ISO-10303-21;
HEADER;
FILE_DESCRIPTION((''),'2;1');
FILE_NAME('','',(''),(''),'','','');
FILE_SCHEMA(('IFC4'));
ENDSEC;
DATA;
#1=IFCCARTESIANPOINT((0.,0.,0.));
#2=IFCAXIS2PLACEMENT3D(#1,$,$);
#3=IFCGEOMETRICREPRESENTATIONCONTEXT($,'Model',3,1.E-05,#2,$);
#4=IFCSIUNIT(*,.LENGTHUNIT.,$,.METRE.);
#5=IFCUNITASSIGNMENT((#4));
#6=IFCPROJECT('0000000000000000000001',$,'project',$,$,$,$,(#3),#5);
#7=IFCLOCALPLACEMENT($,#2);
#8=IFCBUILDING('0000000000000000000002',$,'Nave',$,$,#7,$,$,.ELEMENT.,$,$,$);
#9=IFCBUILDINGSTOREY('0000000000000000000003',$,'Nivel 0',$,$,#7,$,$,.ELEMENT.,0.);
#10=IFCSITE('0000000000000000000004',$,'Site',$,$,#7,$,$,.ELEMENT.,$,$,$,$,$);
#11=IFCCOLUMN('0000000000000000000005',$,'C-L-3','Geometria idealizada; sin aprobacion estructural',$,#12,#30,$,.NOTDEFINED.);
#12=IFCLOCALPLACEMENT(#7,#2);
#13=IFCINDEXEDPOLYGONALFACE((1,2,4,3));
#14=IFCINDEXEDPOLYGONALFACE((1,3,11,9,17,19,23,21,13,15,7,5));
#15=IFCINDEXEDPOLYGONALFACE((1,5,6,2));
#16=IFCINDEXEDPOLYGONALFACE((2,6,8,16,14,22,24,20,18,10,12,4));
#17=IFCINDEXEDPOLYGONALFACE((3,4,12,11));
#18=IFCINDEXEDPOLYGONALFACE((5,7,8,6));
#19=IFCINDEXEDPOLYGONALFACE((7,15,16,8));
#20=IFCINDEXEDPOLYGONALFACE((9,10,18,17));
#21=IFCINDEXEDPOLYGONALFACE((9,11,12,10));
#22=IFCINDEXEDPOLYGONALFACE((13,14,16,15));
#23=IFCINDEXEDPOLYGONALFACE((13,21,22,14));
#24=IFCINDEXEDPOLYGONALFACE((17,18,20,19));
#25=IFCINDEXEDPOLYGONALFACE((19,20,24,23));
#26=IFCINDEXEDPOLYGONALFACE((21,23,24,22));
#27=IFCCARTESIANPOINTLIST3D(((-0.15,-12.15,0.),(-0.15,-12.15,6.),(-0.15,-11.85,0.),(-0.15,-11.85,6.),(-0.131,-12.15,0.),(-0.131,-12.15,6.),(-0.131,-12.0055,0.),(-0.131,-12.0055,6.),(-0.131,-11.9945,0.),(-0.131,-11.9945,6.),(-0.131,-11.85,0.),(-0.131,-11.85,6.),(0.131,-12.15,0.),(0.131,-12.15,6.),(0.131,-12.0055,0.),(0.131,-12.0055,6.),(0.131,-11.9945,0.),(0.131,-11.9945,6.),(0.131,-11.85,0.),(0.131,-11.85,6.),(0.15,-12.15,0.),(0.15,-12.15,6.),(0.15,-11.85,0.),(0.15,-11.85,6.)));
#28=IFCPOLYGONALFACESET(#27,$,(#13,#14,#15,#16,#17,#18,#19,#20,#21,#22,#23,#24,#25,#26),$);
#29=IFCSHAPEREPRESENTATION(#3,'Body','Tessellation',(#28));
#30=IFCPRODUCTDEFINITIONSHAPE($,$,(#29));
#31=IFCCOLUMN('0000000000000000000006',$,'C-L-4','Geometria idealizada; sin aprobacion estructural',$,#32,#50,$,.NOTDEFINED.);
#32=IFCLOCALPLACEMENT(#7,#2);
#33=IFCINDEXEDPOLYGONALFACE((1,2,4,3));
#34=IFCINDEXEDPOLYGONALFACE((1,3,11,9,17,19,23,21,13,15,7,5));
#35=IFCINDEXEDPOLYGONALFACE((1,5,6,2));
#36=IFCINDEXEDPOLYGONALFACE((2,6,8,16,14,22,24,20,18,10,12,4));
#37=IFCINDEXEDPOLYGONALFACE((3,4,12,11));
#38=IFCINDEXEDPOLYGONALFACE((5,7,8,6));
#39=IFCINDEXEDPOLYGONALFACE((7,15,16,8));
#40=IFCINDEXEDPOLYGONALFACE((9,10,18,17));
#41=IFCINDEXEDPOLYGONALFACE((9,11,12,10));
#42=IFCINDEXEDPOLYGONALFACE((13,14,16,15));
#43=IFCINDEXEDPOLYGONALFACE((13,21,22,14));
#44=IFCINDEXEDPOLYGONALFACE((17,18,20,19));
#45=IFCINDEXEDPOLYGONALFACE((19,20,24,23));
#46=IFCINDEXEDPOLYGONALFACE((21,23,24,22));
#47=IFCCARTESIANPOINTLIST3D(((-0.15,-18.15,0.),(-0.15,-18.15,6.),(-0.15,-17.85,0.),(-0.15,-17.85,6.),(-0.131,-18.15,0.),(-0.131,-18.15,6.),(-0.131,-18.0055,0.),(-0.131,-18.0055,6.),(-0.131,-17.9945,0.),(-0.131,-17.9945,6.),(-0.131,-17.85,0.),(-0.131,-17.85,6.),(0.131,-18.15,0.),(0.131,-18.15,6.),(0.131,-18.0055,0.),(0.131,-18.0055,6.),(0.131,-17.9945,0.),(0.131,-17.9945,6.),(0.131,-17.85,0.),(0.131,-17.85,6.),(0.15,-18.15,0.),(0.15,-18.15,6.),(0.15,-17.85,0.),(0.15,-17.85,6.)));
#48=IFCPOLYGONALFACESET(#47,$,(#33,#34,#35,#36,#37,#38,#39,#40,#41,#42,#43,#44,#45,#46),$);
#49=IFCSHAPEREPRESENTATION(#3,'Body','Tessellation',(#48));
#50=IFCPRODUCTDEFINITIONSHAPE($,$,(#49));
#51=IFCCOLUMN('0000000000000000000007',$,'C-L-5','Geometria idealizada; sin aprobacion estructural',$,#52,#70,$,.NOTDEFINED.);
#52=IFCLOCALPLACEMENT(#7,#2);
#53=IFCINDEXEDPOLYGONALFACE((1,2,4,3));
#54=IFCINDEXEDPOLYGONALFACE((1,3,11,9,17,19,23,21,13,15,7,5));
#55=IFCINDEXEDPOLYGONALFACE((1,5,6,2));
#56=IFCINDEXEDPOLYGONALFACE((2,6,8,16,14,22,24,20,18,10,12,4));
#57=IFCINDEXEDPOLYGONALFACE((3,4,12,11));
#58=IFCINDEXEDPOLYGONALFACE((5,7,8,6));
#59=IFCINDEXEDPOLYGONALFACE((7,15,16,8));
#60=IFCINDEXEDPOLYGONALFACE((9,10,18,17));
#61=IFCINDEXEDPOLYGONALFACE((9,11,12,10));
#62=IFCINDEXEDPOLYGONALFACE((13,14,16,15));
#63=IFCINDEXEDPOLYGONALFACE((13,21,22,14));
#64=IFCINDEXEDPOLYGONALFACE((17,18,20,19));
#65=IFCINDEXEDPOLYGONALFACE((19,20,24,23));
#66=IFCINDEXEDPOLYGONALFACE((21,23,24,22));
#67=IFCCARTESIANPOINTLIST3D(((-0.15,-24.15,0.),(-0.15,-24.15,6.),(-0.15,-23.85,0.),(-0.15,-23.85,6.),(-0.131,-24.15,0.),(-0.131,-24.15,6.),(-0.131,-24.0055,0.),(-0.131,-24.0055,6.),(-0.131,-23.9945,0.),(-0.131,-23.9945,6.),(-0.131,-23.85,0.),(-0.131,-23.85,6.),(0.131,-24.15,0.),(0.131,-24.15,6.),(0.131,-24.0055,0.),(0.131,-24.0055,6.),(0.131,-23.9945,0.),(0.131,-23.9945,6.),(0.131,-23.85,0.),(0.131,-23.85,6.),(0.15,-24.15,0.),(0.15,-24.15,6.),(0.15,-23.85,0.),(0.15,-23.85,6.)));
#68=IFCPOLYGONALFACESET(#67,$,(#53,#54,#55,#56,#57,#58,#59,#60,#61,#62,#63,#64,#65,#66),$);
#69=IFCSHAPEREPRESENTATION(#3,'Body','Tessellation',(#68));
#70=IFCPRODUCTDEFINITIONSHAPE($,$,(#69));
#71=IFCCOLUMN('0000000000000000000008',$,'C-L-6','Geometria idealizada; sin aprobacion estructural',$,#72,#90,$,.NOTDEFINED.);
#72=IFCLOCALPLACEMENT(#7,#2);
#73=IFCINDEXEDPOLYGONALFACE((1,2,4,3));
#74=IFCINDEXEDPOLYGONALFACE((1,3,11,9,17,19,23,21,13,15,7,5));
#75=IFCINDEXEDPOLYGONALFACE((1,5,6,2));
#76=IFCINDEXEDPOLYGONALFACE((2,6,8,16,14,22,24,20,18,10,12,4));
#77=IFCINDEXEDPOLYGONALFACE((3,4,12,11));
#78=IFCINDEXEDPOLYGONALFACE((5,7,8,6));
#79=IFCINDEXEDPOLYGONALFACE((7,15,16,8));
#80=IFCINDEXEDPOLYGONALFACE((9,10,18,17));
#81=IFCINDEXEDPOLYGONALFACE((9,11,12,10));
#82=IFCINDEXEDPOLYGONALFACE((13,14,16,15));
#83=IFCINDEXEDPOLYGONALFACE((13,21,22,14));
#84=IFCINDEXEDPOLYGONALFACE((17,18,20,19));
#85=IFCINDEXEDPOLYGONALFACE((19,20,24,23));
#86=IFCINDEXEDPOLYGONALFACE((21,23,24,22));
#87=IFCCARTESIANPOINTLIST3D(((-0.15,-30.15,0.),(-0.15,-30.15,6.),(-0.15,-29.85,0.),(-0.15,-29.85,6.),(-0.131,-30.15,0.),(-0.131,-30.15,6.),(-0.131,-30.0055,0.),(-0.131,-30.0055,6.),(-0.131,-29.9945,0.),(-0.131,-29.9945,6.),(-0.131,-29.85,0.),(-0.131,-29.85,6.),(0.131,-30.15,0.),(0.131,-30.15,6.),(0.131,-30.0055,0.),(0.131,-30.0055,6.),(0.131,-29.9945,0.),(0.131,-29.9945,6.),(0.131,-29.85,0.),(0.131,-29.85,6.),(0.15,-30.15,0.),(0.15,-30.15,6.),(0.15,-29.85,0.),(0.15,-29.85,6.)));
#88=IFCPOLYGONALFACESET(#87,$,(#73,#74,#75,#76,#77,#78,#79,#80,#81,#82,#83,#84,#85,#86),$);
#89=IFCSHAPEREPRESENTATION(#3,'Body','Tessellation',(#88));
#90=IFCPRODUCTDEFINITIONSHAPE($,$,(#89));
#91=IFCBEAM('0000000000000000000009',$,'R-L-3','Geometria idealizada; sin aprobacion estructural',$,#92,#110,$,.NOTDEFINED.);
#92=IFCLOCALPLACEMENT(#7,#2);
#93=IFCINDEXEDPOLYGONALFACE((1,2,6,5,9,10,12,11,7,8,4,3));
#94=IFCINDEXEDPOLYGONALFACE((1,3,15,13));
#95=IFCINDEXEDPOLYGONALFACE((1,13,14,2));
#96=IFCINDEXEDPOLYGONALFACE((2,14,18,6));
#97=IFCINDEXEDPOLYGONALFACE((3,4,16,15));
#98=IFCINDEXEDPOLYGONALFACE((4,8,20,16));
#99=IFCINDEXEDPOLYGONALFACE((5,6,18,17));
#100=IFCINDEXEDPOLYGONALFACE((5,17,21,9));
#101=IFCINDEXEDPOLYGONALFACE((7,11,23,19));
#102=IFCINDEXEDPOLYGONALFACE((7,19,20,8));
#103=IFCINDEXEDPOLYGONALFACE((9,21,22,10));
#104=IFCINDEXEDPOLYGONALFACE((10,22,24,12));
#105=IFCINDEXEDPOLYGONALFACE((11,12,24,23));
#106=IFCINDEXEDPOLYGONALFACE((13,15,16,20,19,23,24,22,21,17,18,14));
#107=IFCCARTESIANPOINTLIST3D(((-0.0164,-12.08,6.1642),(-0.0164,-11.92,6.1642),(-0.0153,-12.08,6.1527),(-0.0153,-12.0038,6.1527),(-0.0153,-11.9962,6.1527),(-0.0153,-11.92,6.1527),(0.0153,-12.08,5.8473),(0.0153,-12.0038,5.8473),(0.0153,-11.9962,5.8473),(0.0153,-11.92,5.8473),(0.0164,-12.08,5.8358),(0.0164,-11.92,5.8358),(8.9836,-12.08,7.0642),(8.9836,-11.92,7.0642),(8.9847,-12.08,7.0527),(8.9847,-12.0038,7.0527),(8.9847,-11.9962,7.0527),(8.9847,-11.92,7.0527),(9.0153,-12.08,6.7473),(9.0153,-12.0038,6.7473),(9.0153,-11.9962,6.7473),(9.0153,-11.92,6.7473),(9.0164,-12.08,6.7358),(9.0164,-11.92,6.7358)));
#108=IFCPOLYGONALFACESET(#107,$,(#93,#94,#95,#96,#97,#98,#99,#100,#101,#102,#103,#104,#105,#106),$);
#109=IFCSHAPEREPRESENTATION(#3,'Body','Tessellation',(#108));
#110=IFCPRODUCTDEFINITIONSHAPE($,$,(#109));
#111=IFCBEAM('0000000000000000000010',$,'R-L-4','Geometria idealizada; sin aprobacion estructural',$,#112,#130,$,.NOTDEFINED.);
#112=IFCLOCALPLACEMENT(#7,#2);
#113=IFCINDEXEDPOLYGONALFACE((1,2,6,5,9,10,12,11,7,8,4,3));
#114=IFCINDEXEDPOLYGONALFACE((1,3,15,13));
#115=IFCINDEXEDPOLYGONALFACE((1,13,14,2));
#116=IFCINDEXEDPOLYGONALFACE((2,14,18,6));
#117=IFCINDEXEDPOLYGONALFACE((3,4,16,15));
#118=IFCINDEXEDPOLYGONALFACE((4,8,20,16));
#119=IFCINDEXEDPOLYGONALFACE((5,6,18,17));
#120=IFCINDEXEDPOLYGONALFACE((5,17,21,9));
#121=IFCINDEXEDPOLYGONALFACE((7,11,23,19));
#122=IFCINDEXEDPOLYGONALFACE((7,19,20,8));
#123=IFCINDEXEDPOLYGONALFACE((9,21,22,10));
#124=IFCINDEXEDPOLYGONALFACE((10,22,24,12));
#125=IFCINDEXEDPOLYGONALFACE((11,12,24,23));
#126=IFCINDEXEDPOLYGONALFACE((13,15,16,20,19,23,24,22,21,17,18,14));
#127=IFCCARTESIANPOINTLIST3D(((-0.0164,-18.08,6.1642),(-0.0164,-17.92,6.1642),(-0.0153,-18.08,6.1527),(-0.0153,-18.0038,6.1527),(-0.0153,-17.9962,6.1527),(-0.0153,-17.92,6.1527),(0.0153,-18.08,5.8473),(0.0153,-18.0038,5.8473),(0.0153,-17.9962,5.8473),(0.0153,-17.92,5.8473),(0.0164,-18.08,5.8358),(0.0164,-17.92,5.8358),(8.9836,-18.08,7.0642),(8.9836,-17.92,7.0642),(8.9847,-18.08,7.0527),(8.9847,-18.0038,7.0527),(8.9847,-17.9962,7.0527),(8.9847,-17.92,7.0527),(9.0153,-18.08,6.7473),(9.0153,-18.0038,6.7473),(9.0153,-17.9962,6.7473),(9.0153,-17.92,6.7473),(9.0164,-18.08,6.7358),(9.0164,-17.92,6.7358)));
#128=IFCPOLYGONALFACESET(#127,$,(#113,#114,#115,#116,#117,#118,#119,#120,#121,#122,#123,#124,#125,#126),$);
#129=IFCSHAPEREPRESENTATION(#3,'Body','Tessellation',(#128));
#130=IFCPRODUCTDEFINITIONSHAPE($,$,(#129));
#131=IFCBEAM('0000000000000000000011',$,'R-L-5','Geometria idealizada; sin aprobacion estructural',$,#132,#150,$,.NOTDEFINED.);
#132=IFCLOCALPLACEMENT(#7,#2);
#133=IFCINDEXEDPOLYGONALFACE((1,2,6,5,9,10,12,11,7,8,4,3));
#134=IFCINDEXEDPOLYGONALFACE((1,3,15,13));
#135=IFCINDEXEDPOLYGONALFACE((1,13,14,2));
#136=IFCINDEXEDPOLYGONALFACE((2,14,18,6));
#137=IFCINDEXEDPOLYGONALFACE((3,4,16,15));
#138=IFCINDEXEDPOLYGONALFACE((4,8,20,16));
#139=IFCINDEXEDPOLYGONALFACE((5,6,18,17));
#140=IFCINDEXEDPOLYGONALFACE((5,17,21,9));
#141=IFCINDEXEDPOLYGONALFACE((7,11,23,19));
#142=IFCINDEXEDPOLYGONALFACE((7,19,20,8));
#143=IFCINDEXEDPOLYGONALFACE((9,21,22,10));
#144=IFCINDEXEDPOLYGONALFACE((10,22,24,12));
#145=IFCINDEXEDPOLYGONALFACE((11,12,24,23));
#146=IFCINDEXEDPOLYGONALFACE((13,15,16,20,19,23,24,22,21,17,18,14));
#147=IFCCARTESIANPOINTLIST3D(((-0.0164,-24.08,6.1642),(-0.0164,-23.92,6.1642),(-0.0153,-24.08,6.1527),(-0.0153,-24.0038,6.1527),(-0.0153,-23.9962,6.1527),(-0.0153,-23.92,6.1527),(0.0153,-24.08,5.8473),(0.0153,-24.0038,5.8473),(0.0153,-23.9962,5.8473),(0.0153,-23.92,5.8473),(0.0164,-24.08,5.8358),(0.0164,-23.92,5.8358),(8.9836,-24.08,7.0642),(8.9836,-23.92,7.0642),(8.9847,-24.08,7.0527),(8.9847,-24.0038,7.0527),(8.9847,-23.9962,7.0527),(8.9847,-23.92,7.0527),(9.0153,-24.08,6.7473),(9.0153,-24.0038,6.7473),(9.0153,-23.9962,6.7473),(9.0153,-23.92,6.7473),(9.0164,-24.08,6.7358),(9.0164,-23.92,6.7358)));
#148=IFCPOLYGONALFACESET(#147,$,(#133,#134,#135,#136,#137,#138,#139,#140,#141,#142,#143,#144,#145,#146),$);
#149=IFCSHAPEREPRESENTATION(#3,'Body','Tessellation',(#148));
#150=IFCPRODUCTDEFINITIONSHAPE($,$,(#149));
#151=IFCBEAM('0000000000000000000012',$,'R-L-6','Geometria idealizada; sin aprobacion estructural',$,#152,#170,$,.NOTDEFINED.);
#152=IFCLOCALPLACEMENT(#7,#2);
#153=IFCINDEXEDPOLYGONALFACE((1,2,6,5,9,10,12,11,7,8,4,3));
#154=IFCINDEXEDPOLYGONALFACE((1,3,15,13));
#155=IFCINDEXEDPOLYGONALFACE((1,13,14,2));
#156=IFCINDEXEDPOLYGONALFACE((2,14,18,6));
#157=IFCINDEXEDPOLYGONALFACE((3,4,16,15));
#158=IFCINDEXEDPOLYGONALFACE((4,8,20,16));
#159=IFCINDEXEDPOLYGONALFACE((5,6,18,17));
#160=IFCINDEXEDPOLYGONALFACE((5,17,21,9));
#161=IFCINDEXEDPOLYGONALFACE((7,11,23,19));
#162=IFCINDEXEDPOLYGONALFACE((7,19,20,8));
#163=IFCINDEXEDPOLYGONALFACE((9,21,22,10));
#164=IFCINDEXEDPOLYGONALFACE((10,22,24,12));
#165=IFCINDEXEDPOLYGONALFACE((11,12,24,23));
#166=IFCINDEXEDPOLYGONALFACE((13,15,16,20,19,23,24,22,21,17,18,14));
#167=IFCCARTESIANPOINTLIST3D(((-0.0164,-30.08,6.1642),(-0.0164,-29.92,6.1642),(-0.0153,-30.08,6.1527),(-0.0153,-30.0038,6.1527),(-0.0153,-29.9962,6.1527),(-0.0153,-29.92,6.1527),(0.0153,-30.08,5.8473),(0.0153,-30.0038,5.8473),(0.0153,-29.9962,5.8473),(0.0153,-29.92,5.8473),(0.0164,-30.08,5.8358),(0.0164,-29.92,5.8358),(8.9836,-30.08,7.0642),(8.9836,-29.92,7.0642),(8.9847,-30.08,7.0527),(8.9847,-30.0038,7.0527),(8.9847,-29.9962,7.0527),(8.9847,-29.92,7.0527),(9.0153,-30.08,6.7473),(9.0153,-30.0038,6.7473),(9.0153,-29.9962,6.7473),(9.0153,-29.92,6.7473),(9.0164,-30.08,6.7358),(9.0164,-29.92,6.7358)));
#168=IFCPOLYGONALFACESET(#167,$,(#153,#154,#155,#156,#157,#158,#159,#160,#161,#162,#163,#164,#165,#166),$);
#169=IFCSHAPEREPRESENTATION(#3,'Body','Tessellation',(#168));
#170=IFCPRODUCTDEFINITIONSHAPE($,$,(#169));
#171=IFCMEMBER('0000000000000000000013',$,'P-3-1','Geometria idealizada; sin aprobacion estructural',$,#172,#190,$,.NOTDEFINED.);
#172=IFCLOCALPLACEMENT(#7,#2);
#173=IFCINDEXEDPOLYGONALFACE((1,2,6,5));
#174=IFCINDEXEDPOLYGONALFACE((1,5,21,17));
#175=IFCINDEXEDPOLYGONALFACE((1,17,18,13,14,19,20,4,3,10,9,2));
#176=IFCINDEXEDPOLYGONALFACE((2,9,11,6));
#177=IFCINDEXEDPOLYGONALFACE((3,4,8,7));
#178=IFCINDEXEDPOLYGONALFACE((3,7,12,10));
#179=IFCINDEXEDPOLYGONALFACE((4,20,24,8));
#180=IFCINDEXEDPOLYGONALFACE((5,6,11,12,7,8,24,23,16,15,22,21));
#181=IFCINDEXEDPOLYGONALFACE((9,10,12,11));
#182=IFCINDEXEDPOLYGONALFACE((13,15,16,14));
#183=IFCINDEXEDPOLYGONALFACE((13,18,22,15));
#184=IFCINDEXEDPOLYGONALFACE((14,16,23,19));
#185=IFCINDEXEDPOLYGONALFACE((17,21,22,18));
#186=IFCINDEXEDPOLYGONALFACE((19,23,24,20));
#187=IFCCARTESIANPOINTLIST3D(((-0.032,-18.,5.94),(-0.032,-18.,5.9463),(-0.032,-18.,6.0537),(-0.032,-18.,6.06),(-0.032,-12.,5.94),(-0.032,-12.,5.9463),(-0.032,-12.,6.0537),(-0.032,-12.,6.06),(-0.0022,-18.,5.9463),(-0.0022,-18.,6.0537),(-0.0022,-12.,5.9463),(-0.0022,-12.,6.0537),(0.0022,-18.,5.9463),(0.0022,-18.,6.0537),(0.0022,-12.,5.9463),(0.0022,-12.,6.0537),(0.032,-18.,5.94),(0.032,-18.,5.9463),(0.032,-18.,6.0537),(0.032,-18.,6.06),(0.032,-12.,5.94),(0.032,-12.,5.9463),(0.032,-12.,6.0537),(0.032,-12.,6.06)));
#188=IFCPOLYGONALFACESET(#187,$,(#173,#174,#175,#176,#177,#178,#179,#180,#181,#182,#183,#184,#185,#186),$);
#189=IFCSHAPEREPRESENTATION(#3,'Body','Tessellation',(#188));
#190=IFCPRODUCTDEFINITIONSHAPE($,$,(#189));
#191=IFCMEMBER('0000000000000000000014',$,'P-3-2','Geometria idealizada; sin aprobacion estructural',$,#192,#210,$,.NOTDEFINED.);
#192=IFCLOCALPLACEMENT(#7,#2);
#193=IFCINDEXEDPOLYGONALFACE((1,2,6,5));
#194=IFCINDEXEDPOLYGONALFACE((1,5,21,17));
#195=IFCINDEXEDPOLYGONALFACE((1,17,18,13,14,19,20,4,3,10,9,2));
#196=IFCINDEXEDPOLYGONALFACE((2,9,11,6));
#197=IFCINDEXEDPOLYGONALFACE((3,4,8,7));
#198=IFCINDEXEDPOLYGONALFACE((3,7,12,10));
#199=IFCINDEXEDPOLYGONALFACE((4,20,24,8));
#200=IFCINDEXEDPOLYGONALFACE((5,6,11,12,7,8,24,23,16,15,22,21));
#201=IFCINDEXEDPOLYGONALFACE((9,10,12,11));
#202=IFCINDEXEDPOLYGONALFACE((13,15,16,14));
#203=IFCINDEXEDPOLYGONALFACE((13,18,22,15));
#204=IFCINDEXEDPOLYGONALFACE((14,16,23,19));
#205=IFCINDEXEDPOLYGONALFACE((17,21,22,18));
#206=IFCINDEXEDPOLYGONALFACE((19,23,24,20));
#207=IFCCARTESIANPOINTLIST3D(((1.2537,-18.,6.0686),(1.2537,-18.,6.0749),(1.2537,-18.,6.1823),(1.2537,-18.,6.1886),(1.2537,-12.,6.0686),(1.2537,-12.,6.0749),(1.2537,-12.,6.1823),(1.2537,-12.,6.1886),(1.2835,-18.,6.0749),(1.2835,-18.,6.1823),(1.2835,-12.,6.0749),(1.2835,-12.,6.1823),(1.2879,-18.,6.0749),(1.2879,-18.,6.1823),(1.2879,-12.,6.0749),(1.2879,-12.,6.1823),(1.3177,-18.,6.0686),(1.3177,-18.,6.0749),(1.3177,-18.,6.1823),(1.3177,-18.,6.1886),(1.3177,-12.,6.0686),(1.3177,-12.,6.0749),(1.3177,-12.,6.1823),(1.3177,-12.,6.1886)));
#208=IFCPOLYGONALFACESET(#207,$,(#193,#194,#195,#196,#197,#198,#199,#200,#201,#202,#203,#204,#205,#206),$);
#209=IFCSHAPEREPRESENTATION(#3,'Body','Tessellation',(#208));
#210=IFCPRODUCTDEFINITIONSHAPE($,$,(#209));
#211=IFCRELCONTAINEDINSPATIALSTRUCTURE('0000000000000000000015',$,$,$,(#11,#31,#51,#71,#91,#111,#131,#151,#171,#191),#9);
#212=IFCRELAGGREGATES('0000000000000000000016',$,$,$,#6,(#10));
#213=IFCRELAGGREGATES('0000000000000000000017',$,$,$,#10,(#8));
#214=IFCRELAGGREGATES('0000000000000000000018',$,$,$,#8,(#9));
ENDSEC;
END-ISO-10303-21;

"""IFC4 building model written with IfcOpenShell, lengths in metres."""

from ifc_helpers import new_model, si_unit, frame, origin, place, context, project, spatial, polyline, outline, extrude, element, save


model = new_model("IFC4")

# Units and contexts
model_context = context("Model", 3, precision=1e-05, world=origin())
ifc_project = project(units=[si_unit("LENGTHUNIT", "METRE")], contexts=[model_context])

# Site, building, storey
placement = place(None, origin())
site = spatial("IfcSite", under=ifc_project, at=placement, Name="Site", CompositionType="ELEMENT")
building = spatial("IfcBuilding", under=site, at=placement, Name="Nave", CompositionType="ELEMENT")
storey = spatial("IfcBuildingStorey", under=building, at=placement, Name="Nivel 0", CompositionType="ELEMENT", Elevation=0.0)

# Columns
for number, where, z_axis, x_axis, name in (
    (1, (0.0, -12.0, 0.0), (0.0, 0.0, 1.0), (0.0, -1.0, 0.0), "C-L-3"),
    (2, (0.0, -18.0, 0.0), (0.0, 0.0, 1.0), (0.0, -1.0, 0.0), "C-L-4"),
    (3, (0.0, -24.0, 0.0), (0.0, 0.0, 1.0), (0.0, -1.0, 0.0), "C-L-5"),
    (4, (0.0, -30.0, 0.0), (0.0, 0.0, 1.0), (0.0, -1.0, 0.0), "C-L-6"),
):
    element("IfcColumn", number, at=place(placement, frame(where, z_axis=z_axis, x_axis=x_axis)), inside=storey, Name=name, Description="Geometria idealizada; sin aprobacion estructural", PredefinedType="NOTDEFINED", context=model_context, shape_type="SweptSolid", body=[
        extrude(outline(polyline([(-0.15, -0.15), (0.15, -0.15), (0.15, -0.131), (0.0055, -0.131), (0.0055, 0.131), (0.15, 0.131), (0.15, 0.15), (-0.15, 0.15), (-0.15, 0.131), (-0.0055, 0.131), (-0.0055, -0.131), (-0.15, -0.131), (-0.15, -0.15)])), origin(), (0.0, 0.0, 1.0), 6.0),
    ])

# Beams
for number, where, z_axis, x_axis, name in (
    (5, (0.0, -12.0, 6.0), (0.995037, 0.0, 0.099504), (0.0, 1.0, 0.0), "R-L-3"),
    (6, (0.0, -18.0, 6.0), (0.995037, 0.0, 0.099504), (0.0, 1.0, 0.0), "R-L-4"),
    (7, (0.0, -24.0, 6.0), (0.995037, 0.0, 0.099504), (0.0, 1.0, 0.0), "R-L-5"),
    (8, (0.0, -30.0, 6.0), (0.995037, 0.0, 0.099504), (0.0, 1.0, 0.0), "R-L-6"),
):
    element("IfcBeam", number, at=place(placement, frame(where, z_axis=z_axis, x_axis=x_axis)), inside=storey, Name=name, Description="Geometria idealizada; sin aprobacion estructural", PredefinedType="NOTDEFINED", context=model_context, shape_type="SweptSolid", body=[
        extrude(outline(polyline([(-0.08, -0.165), (0.08, -0.165), (0.08, -0.1535), (0.0037, -0.1535), (0.0037, 0.1535), (0.08, 0.1535), (0.08, 0.165), (-0.08, 0.165), (-0.08, 0.1535), (-0.0037, 0.1535), (-0.0037, -0.1535), (-0.08, -0.1535), (-0.08, -0.165)])), origin(), (0.0, 0.0, 1.0), 9.0449),
    ])

# Members
for number, where, z_axis, x_axis, name in (
    (9, (0.0, -12.0, 6.0), (0.0, -1.0, 0.0), (1.0, 0.0, 0.0), "P-3-1"),
    (10, (1.2857, -12.0, 6.1286), (0.0, -1.0, 0.0), (1.0, 0.0, 0.0), "P-3-2"),
):
    element("IfcMember", number, at=place(placement, frame(where, z_axis=z_axis, x_axis=x_axis)), inside=storey, Name=name, Description="Geometria idealizada; sin aprobacion estructural", PredefinedType="NOTDEFINED", context=model_context, shape_type="SweptSolid", body=[
        extrude(outline(polyline([(-0.032, -0.06), (0.032, -0.06), (0.032, -0.0537), (0.0022, -0.0537), (0.0022, 0.0537), (0.032, 0.0537), (0.032, 0.06), (-0.032, 0.06), (-0.032, 0.0537), (-0.0022, 0.0537), (-0.0022, -0.0537), (-0.032, -0.0537), (-0.032, -0.06)])), origin(), (0.0, 0.0, 1.0), 6.0),
    ])

save(model, "model.ifc")
